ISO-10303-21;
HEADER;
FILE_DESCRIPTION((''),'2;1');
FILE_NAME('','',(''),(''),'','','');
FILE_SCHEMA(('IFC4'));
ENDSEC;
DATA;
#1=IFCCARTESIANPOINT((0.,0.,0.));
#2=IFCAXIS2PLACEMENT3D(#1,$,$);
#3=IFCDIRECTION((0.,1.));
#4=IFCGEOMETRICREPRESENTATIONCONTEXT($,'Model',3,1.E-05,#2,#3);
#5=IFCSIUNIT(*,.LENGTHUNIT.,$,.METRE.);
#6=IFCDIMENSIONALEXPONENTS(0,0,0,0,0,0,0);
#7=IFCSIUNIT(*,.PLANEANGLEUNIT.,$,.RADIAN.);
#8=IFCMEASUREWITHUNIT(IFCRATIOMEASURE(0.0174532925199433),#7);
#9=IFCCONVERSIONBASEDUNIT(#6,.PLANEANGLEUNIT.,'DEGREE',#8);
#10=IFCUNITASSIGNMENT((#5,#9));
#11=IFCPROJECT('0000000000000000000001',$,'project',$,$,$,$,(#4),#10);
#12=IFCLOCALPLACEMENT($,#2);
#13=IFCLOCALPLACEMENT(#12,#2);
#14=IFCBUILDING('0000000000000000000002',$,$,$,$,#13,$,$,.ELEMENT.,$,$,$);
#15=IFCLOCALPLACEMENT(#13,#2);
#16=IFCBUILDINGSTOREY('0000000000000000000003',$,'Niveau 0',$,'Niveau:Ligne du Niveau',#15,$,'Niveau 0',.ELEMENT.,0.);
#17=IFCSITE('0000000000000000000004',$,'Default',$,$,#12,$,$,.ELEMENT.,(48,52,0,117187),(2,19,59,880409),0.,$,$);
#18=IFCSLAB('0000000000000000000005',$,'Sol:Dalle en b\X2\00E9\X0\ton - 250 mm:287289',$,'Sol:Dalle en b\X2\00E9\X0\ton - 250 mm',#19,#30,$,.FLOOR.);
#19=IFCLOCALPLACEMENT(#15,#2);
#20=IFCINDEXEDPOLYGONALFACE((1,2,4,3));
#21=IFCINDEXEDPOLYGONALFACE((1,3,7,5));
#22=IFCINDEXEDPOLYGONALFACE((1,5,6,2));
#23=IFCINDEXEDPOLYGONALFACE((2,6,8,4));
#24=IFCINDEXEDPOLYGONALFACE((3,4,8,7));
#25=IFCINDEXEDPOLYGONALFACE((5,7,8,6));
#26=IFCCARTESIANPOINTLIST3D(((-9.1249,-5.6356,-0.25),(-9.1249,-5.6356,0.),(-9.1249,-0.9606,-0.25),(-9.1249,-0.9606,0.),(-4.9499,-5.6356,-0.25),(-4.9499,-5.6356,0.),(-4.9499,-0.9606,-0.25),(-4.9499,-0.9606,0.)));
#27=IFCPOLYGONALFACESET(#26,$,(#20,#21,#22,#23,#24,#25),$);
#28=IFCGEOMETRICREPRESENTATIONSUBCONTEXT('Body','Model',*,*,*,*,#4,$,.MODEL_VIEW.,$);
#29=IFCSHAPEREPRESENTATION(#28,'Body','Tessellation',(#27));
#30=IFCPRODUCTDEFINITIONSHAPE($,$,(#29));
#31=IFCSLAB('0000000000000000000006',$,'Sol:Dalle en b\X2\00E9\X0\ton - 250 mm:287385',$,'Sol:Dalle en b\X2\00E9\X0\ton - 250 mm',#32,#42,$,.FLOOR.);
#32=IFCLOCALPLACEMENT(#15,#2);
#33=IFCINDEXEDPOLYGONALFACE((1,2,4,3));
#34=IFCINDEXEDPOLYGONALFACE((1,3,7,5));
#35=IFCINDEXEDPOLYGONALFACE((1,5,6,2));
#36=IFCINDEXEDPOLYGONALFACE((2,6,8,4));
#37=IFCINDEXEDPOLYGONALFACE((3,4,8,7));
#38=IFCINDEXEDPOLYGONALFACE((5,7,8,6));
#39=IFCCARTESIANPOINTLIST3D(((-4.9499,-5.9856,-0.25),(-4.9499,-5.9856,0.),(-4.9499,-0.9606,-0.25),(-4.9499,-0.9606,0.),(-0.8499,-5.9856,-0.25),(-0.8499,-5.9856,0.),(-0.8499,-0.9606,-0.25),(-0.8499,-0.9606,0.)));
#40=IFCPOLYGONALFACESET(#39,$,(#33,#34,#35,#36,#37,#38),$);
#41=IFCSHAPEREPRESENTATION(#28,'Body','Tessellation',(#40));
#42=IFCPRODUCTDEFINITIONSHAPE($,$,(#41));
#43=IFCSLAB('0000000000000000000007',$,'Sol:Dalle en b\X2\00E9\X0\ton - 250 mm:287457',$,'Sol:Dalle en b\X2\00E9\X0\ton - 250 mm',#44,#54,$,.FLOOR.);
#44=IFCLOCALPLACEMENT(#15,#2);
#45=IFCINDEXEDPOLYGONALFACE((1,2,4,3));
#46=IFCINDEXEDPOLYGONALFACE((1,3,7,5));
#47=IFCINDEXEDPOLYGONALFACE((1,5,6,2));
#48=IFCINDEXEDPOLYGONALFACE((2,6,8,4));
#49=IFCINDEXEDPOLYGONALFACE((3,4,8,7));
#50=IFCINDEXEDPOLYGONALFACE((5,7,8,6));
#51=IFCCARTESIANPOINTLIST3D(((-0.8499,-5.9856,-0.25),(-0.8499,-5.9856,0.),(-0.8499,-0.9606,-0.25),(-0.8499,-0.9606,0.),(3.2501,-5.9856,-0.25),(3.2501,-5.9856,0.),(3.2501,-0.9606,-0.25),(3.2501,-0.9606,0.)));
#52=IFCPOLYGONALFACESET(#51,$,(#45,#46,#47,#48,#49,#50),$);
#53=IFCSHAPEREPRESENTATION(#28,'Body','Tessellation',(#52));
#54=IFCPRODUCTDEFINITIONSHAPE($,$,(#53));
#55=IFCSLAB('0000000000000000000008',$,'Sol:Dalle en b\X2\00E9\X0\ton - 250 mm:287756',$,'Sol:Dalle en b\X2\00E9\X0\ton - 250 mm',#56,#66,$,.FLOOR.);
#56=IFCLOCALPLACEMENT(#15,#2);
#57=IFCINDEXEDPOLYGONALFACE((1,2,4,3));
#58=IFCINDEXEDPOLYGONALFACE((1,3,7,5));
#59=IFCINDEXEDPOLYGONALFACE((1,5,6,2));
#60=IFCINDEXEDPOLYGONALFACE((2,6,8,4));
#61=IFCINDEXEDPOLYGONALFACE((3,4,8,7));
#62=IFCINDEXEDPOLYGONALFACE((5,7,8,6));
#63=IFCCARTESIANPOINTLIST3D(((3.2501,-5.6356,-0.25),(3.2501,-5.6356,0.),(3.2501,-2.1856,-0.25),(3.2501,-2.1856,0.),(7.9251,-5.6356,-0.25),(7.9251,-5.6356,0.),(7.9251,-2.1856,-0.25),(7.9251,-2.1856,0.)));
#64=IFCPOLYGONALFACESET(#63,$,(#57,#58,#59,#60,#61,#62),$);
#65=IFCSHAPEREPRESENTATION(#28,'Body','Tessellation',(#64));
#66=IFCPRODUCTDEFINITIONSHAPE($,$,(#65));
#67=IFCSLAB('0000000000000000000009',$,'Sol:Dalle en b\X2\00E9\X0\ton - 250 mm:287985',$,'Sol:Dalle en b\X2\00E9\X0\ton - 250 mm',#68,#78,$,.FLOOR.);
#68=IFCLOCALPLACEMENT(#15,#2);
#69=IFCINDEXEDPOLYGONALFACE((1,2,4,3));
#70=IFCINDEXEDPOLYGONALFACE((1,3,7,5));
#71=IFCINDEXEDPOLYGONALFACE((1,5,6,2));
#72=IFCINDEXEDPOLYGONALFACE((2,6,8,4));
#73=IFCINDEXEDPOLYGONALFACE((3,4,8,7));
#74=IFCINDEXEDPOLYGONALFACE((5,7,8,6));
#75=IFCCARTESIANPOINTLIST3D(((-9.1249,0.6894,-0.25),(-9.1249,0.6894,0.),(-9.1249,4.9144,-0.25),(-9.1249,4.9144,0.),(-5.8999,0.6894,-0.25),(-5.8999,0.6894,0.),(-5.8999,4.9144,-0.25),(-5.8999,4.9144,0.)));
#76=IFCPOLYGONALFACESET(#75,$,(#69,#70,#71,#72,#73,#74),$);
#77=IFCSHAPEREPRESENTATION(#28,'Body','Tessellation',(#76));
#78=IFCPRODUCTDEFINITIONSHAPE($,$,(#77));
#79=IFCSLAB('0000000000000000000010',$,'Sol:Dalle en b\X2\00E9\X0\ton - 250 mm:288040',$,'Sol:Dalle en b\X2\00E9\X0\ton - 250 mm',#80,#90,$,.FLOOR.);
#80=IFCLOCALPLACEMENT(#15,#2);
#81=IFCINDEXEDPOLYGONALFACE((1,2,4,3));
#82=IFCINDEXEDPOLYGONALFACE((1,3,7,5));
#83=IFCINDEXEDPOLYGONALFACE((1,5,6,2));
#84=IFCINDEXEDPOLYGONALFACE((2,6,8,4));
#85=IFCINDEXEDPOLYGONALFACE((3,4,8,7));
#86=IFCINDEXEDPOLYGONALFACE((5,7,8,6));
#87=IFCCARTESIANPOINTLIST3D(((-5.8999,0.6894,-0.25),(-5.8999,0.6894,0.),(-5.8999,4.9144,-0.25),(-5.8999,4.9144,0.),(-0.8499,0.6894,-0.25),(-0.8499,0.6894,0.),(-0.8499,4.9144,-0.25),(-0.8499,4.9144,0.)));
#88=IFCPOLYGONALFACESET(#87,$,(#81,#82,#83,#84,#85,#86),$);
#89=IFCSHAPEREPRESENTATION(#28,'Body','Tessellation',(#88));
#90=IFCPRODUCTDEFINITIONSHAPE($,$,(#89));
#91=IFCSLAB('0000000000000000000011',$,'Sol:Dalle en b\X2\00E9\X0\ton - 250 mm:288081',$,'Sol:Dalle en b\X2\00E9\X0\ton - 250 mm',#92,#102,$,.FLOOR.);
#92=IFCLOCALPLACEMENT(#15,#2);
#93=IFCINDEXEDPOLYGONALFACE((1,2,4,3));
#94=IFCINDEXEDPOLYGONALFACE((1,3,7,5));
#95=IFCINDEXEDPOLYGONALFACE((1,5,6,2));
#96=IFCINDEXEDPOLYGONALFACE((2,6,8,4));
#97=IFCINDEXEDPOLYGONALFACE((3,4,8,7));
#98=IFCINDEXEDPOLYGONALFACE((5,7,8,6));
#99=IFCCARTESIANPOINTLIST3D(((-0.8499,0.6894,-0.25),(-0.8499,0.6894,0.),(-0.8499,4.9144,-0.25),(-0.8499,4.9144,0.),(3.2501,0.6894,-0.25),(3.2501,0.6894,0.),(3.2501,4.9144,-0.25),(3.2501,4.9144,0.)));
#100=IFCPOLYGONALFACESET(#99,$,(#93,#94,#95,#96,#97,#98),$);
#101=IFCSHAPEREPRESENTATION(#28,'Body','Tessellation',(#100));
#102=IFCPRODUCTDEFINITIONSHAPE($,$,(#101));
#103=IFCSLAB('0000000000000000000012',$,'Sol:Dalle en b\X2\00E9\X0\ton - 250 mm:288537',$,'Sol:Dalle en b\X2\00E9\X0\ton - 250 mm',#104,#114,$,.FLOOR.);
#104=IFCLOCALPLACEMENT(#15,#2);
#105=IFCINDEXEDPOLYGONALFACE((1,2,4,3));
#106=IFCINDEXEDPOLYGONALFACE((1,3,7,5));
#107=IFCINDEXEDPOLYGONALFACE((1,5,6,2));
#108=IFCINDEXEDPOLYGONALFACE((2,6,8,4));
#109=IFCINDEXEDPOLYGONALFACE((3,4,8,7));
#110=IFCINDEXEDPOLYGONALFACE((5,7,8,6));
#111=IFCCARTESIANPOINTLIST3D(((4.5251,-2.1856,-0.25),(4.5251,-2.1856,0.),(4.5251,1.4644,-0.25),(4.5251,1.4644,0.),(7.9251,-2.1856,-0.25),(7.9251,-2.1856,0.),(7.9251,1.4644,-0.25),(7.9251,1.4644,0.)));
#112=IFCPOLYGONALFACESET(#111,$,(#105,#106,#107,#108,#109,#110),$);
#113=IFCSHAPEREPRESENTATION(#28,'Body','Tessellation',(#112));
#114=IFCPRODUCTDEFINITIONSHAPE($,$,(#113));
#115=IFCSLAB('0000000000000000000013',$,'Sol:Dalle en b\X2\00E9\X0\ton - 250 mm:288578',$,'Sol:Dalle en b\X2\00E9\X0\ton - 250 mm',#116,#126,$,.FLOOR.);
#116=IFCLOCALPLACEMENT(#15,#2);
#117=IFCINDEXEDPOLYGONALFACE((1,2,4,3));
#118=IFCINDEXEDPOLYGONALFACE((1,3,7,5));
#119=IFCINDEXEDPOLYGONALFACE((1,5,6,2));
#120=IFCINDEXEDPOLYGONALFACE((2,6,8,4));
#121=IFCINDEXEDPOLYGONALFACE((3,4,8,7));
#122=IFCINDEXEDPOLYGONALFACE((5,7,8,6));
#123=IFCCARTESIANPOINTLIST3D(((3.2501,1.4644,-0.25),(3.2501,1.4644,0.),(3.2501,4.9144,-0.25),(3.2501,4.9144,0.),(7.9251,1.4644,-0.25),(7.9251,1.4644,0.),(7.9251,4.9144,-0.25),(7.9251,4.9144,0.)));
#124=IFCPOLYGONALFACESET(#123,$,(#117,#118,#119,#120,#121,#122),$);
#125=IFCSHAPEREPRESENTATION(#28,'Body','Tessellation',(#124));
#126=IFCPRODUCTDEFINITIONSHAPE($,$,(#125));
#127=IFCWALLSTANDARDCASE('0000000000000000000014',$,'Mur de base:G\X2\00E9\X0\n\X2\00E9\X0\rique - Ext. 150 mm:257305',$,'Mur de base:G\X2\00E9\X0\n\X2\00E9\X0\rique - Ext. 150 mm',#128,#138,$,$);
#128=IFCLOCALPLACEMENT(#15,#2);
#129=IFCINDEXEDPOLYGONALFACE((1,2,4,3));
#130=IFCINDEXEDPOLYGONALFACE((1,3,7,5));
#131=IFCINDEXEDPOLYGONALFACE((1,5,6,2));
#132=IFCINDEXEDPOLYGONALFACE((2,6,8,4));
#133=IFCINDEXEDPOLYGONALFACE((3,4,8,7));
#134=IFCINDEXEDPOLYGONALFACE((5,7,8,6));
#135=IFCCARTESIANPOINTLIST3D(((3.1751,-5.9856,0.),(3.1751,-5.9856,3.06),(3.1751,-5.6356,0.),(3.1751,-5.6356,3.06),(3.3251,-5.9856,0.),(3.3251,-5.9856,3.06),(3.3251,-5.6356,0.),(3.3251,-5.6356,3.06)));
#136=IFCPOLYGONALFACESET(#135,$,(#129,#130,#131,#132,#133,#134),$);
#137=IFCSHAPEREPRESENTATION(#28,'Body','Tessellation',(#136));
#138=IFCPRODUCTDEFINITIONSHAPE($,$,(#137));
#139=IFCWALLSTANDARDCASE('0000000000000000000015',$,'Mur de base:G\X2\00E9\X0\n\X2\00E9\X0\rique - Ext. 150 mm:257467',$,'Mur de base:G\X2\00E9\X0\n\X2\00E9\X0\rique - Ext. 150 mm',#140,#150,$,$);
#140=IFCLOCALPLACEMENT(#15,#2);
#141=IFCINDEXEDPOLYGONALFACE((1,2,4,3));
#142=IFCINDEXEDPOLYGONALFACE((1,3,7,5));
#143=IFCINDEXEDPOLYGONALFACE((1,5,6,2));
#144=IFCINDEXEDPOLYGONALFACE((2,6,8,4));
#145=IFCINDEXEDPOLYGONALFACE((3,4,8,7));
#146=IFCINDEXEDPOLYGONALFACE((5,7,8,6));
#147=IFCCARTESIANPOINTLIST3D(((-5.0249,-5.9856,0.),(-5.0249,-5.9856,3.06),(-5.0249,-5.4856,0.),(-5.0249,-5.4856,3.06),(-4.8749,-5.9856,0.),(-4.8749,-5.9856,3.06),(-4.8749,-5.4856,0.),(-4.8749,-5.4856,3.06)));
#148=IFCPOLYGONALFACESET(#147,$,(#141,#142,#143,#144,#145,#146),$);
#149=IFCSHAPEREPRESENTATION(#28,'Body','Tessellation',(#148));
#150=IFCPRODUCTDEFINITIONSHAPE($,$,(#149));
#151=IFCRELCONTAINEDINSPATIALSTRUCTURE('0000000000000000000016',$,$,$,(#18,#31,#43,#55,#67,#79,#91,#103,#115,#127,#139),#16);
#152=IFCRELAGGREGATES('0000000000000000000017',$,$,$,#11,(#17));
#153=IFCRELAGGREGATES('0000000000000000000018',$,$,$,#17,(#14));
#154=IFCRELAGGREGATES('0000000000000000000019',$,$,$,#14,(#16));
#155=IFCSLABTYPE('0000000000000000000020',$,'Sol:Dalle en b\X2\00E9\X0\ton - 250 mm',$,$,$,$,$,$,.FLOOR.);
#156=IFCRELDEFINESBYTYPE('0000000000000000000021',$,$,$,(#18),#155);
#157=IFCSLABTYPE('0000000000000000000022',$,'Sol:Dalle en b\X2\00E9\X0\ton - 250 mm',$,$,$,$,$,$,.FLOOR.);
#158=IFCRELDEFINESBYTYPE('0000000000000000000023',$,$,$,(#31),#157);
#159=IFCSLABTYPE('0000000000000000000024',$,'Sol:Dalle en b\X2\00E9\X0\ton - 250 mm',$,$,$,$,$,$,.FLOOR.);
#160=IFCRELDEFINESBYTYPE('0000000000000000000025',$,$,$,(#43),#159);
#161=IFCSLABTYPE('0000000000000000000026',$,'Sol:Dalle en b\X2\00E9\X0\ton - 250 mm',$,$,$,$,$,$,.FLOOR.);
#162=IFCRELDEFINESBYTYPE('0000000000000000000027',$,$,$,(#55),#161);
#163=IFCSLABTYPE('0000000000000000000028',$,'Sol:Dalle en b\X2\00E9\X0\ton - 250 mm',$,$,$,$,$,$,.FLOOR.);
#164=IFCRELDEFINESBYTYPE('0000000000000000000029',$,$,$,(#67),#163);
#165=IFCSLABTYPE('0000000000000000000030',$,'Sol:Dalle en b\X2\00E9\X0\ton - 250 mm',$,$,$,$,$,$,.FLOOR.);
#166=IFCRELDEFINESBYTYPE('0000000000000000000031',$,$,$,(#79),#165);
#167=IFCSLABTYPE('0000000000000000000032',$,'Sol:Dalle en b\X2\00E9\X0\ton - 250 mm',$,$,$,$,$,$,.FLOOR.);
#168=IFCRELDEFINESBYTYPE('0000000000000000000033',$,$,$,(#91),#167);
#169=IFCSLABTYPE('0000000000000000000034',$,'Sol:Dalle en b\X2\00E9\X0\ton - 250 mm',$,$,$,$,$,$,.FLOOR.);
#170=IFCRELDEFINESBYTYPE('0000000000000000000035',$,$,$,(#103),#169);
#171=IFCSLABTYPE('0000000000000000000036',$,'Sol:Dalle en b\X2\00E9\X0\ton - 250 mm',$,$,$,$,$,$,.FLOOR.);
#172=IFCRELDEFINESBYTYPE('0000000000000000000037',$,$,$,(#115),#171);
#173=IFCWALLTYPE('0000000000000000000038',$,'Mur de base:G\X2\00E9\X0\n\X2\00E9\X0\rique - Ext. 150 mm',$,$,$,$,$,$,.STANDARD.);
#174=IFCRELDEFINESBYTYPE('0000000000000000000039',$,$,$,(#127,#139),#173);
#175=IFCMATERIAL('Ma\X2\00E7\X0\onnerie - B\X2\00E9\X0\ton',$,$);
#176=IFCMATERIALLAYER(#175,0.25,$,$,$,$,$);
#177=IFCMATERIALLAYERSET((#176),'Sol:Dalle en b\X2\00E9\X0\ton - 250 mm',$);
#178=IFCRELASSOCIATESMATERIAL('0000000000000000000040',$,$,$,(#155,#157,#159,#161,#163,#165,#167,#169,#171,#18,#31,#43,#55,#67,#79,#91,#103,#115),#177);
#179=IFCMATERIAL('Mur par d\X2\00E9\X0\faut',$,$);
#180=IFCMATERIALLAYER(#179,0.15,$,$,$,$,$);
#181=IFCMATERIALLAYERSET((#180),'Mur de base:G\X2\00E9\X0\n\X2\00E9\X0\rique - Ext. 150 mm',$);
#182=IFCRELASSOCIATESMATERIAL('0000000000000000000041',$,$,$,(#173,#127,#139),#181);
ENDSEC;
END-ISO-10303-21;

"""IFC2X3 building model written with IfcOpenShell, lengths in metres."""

from ifc_helpers import new_model, entity, si_unit, converted_unit, direction, frame, frame_2d, origin, origin_2d_with_axis, place, context, subcontext, project, spatial, rectangle, extrude, material, layer, layer_set, layer_usage, type_object, element, save


model = new_model("IFC2X3")

# Units and contexts
model_context = context("Model", 3, precision=1e-05, world=origin(), true_north=direction((0.0, 1.0)))
body_context = subcontext(model_context, "Body", "Model", "MODEL_VIEW")
ifc_project = project(units=[si_unit("LENGTHUNIT", "METRE"), converted_unit("PLANEANGLEUNIT", "DEGREE", entity("IfcRatioMeasure", 0.0174532925199433), si_unit("PLANEANGLEUNIT", "RADIAN"), dimensions=[0, 0, 0, 0, 0, 0, 0])], contexts=[model_context])

# Site, building, storey
site_placement = place(None, origin())
site = spatial("IfcSite", under=ifc_project, at=site_placement, Name="Default", CompositionType="ELEMENT", RefLatitude=(48, 52, 0, 117187), RefLongitude=(2, 19, 59, 880409), RefElevation=0.0)
building_placement = place(site_placement, origin())
building = spatial("IfcBuilding", under=site, at=building_placement, CompositionType="ELEMENT")
storey_placement = place(building_placement, origin())
storey = spatial("IfcBuildingStorey", under=building, at=storey_placement, Name="Niveau 0", ObjectType="Niveau:Ligne du Niveau", LongName="Niveau 0", CompositionType="ELEMENT", Elevation=0.0)

# Slabs
ifc_material_1 = material(Name="Maçonnerie - Béton")
ifc_layer_1 = layer(ifc_material_1, 0.25)
ifc_layer_set_1 = layer_set([ifc_layer_1], Name="Sol:Dalle en béton - 250 mm")
ifc_layer_usage_1 = layer_usage(ifc_layer_set_1, "AXIS3", "POSITIVE", 0.0)
slab_type_1 = type_object("IfcSlabType", Name="Sol:Dalle en béton - 250 mm", PredefinedType="FLOOR", material=ifc_layer_set_1)
slab_1_placement = place(storey_placement, origin())
element("IfcSlab", 1, at=slab_1_placement, inside=storey, type_object=slab_type_1, material=ifc_layer_usage_1, Name="Sol:Dalle en béton - 250 mm:287289", ObjectType="Sol:Dalle en béton - 250 mm", PredefinedType="FLOOR", context=body_context, shape_type="SweptSolid", body=[
    extrude(rectangle(XDim=4.675, YDim=4.175, at=frame_2d((0.0, 0.0), x_axis=(1.0, 0.0))), frame((-7.0374, -3.2981, 0.0), z_axis=(0.0, 0.0, -1.0), x_axis=(0.0, 1.0, 0.0)), (0.0, 0.0, 1.0), 0.25),
])
ifc_layer_usage_2 = layer_usage(ifc_layer_set_1, "AXIS3", "POSITIVE", 0.0)
slab_type_2 = type_object("IfcSlabType", Name="Sol:Dalle en béton - 250 mm", PredefinedType="FLOOR", material=ifc_layer_set_1)
slab_2_placement = place(storey_placement, origin())
element("IfcSlab", 2, at=slab_2_placement, inside=storey, type_object=slab_type_2, material=ifc_layer_usage_2, Name="Sol:Dalle en béton - 250 mm:287385", ObjectType="Sol:Dalle en béton - 250 mm", PredefinedType="FLOOR", context=body_context, shape_type="SweptSolid", body=[
    extrude(rectangle(XDim=5.025, YDim=4.1, at=frame_2d((0.0, 0.0), x_axis=(1.0, 0.0))), frame((-2.8999, -3.4731, 0.0), z_axis=(0.0, 0.0, -1.0), x_axis=(0.0, 1.0, 0.0)), (0.0, 0.0, 1.0), 0.25),
])
ifc_layer_usage_3 = layer_usage(ifc_layer_set_1, "AXIS3", "POSITIVE", 0.0)
slab_type_3 = type_object("IfcSlabType", Name="Sol:Dalle en béton - 250 mm", PredefinedType="FLOOR", material=ifc_layer_set_1)
slab_3_placement = place(storey_placement, origin())
element("IfcSlab", 3, at=slab_3_placement, inside=storey, type_object=slab_type_3, material=ifc_layer_usage_3, Name="Sol:Dalle en béton - 250 mm:287457", ObjectType="Sol:Dalle en béton - 250 mm", PredefinedType="FLOOR", context=body_context, shape_type="SweptSolid", body=[
    extrude(rectangle(XDim=5.025, YDim=4.1, at=origin_2d_with_axis()), frame((1.2001, -3.4731, 0.0), z_axis=(0.0, 0.0, -1.0), x_axis=(0.0, 1.0, 0.0)), (0.0, 0.0, 1.0), 0.25),
])
ifc_layer_usage_4 = layer_usage(ifc_layer_set_1, "AXIS3", "POSITIVE", 0.0)
slab_type_4 = type_object("IfcSlabType", Name="Sol:Dalle en béton - 250 mm", PredefinedType="FLOOR", material=ifc_layer_set_1)
slab_4_placement = place(storey_placement, origin())
element("IfcSlab", 4, at=slab_4_placement, inside=storey, type_object=slab_type_4, material=ifc_layer_usage_4, Name="Sol:Dalle en béton - 250 mm:287756", ObjectType="Sol:Dalle en béton - 250 mm", PredefinedType="FLOOR", context=body_context, shape_type="SweptSolid", body=[
    extrude(rectangle(XDim=3.45, YDim=4.675, at=frame_2d((0.0, 0.0), x_axis=(1.0, 0.0))), frame((5.5876, -3.9106, 0.0), z_axis=(0.0, 0.0, -1.0), x_axis=(0.0, 1.0, 0.0)), (0.0, 0.0, 1.0), 0.25),
])
ifc_layer_usage_5 = layer_usage(ifc_layer_set_1, "AXIS3", "POSITIVE", 0.0)
slab_type_5 = type_object("IfcSlabType", Name="Sol:Dalle en béton - 250 mm", PredefinedType="FLOOR", material=ifc_layer_set_1)
slab_5_placement = place(storey_placement, origin())
element("IfcSlab", 5, at=slab_5_placement, inside=storey, type_object=slab_type_5, material=ifc_layer_usage_5, Name="Sol:Dalle en béton - 250 mm:287985", ObjectType="Sol:Dalle en béton - 250 mm", PredefinedType="FLOOR", context=body_context, shape_type="SweptSolid", body=[
    extrude(rectangle(XDim=4.225, YDim=3.225, at=frame_2d((0.0, 0.0), x_axis=(1.0, 0.0))), frame((-7.5124, 2.8019, 0.0), z_axis=(0.0, 0.0, -1.0), x_axis=(0.0, 1.0, 0.0)), (0.0, 0.0, 1.0), 0.25),
])
ifc_layer_usage_6 = layer_usage(ifc_layer_set_1, "AXIS3", "POSITIVE", 0.0)
slab_type_6 = type_object("IfcSlabType", Name="Sol:Dalle en béton - 250 mm", PredefinedType="FLOOR", material=ifc_layer_set_1)
slab_6_placement = place(storey_placement, origin())
element("IfcSlab", 6, at=slab_6_placement, inside=storey, type_object=slab_type_6, material=ifc_layer_usage_6, Name="Sol:Dalle en béton - 250 mm:288040", ObjectType="Sol:Dalle en béton - 250 mm", PredefinedType="FLOOR", context=body_context, shape_type="SweptSolid", body=[
    extrude(rectangle(XDim=4.225, YDim=5.05, at=frame_2d((0.0, 0.0), x_axis=(1.0, 0.0))), frame((-3.3749, 2.8019, 0.0), z_axis=(0.0, 0.0, -1.0), x_axis=(0.0, 1.0, 0.0)), (0.0, 0.0, 1.0), 0.25),
])
ifc_layer_usage_7 = layer_usage(ifc_layer_set_1, "AXIS3", "POSITIVE", 0.0)
slab_type_7 = type_object("IfcSlabType", Name="Sol:Dalle en béton - 250 mm", PredefinedType="FLOOR", material=ifc_layer_set_1)
slab_7_placement = place(storey_placement, origin())
element("IfcSlab", 7, at=slab_7_placement, inside=storey, type_object=slab_type_7, material=ifc_layer_usage_7, Name="Sol:Dalle en béton - 250 mm:288081", ObjectType="Sol:Dalle en béton - 250 mm", PredefinedType="FLOOR", context=body_context, shape_type="SweptSolid", body=[
    extrude(rectangle(XDim=4.225, YDim=4.1, at=frame_2d((0.0, 0.0), x_axis=(1.0, 0.0))), frame((1.2001, 2.8019, 0.0), z_axis=(0.0, 0.0, -1.0), x_axis=(0.0, 1.0, 0.0)), (0.0, 0.0, 1.0), 0.25),
])
ifc_layer_usage_8 = layer_usage(ifc_layer_set_1, "AXIS3", "POSITIVE", 0.0)
slab_type_8 = type_object("IfcSlabType", Name="Sol:Dalle en béton - 250 mm", PredefinedType="FLOOR", material=ifc_layer_set_1)
slab_8_placement = place(storey_placement, origin())
element("IfcSlab", 8, at=slab_8_placement, inside=storey, type_object=slab_type_8, material=ifc_layer_usage_8, Name="Sol:Dalle en béton - 250 mm:288537", ObjectType="Sol:Dalle en béton - 250 mm", PredefinedType="FLOOR", context=body_context, shape_type="SweptSolid", body=[
    extrude(rectangle(XDim=3.65, YDim=3.4, at=frame_2d((0.0, 0.0), x_axis=(1.0, 0.0))), frame((6.2251, -0.3606, 0.0), z_axis=(0.0, 0.0, -1.0), x_axis=(0.0, 1.0, 0.0)), (0.0, 0.0, 1.0), 0.25),
])
ifc_layer_usage_9 = layer_usage(ifc_layer_set_1, "AXIS3", "POSITIVE", 0.0)
slab_type_9 = type_object("IfcSlabType", Name="Sol:Dalle en béton - 250 mm", PredefinedType="FLOOR", material=ifc_layer_set_1)
slab_9_placement = place(storey_placement, origin())
element("IfcSlab", 9, at=slab_9_placement, inside=storey, type_object=slab_type_9, material=ifc_layer_usage_9, Name="Sol:Dalle en béton - 250 mm:288578", ObjectType="Sol:Dalle en béton - 250 mm", PredefinedType="FLOOR", context=body_context, shape_type="SweptSolid", body=[
    extrude(rectangle(XDim=3.45, YDim=4.675, at=frame_2d((0.0, 0.0), x_axis=(1.0, 0.0))), frame((5.5876, 3.1894, 0.0), z_axis=(0.0, 0.0, -1.0), x_axis=(0.0, 1.0, 0.0)), (0.0, 0.0, 1.0), 0.25),
])

# Walls
ifc_material_2 = material(Name="Mur par défaut")
ifc_layer_2 = layer(ifc_material_2, 0.15)
ifc_layer_set_2 = layer_set([ifc_layer_2], Name="Mur de base:Générique - Ext. 150 mm")
ifc_layer_usage_10 = layer_usage(ifc_layer_set_2, "AXIS2", "NEGATIVE", 0.075)
wall_type = type_object("IfcWallType", Name="Mur de base:Générique - Ext. 150 mm", PredefinedType="STANDARD", material=ifc_layer_set_2)
wall_1_placement = place(storey_placement, frame((3.2501, -5.6356, 0.0), z_axis=(0.0, 0.0, 1.0), x_axis=(0.0, -1.0, 0.0)))
element("IfcWallStandardCase", 10, at=wall_1_placement, inside=storey, type_object=wall_type, material=ifc_layer_usage_10, Name="Mur de base:Générique - Ext. 150 mm:257305", ObjectType="Mur de base:Générique - Ext. 150 mm", context=body_context, shape_type="SweptSolid", body=[
    extrude(rectangle(XDim=0.35, YDim=0.15, at=frame_2d((0.175, 0.0), x_axis=(-1.0, 0.0))), origin(), (0.0, 0.0, 1.0), 3.06),
])
ifc_layer_usage_11 = layer_usage(ifc_layer_set_2, "AXIS2", "NEGATIVE", 0.075)
wall_2_placement = place(storey_placement, frame((-4.9499, -5.9856, 0.0), z_axis=(0.0, 0.0, 1.0), x_axis=(0.0, 1.0, 0.0)))
element("IfcWallStandardCase", 11, at=wall_2_placement, inside=storey, type_object=wall_type, material=ifc_layer_usage_11, Name="Mur de base:Générique - Ext. 150 mm:257467", ObjectType="Mur de base:Générique - Ext. 150 mm", context=body_context, shape_type="SweptSolid", body=[
    extrude(rectangle(XDim=0.5, YDim=0.15, at=frame_2d((0.25, 0.0), x_axis=(-1.0, 0.0))), origin(), (0.0, 0.0, 1.0), 3.06),
])

save(model, "model.ifc")
